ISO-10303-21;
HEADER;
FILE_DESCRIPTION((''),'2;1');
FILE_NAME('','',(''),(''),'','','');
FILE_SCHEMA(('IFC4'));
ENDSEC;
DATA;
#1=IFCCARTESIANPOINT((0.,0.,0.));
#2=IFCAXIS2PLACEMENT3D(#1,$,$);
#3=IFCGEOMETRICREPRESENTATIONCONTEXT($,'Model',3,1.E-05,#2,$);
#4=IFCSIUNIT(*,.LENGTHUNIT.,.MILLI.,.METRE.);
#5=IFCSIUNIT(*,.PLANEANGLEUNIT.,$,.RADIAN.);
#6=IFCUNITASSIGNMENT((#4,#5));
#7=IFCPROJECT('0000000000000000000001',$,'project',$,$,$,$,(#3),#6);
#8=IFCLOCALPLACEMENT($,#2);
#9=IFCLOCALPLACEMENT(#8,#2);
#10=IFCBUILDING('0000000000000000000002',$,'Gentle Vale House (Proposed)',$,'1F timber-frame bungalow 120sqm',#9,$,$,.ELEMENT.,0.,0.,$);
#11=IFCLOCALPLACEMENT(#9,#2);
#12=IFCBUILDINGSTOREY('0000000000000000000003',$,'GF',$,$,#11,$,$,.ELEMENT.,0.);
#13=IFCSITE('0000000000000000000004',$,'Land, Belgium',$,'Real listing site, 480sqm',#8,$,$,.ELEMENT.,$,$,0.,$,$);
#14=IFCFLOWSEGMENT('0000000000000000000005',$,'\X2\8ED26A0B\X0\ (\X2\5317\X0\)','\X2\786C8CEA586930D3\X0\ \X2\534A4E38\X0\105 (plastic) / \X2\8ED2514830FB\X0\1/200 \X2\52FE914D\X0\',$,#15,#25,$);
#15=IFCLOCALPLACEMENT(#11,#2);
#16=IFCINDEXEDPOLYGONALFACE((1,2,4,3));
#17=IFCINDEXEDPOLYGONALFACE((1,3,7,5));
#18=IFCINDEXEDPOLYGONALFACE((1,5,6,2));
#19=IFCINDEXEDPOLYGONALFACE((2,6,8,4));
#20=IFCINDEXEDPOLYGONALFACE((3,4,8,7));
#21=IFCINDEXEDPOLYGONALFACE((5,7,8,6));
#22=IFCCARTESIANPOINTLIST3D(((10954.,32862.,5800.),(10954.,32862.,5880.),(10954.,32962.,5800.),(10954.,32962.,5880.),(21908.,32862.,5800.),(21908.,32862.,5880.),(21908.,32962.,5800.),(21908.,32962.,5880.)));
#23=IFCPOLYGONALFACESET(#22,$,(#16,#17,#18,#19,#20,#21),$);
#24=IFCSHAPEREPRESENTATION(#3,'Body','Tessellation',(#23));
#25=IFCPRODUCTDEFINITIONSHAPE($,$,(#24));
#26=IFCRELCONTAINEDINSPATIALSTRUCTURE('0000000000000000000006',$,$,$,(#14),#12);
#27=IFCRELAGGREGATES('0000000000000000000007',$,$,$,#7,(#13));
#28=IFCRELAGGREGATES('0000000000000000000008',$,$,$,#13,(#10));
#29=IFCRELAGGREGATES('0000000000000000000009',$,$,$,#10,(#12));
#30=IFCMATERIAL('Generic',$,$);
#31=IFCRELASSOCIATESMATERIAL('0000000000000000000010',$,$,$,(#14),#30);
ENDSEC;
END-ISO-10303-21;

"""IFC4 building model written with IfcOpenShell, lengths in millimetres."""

from ifc_helpers import new_model, si_unit, frame, frame_2d, origin, place, context, project, spatial, rectangle, extrude, material, element, save


model = new_model("IFC4")

# Units and contexts
model_context = context("Model", 3, precision=1e-05, world=origin())
ifc_project = project(units=[si_unit("LENGTHUNIT", "METRE", prefix="MILLI"), si_unit("PLANEANGLEUNIT", "RADIAN")], contexts=[model_context])

# Site, building, storey
site_placement = place(None, origin())
site = spatial("IfcSite", under=ifc_project, at=site_placement, Name="Land, Belgium", ObjectType="Real listing site, 480sqm", CompositionType="ELEMENT", RefElevation=0.0)
building_placement = place(site_placement, origin())
building = spatial("IfcBuilding", under=site, at=building_placement, Name="Gentle Vale House (Proposed)", ObjectType="1F timber-frame bungalow 120sqm", CompositionType="ELEMENT", ElevationOfRefHeight=0.0, ElevationOfTerrain=0.0)
storey_placement = place(building_placement, origin())
storey = spatial("IfcBuildingStorey", under=building, at=storey_placement, Name="GF", CompositionType="ELEMENT", Elevation=0.0)

# Shared definitions
ifc_material_1 = material(Name="Generic")

# Flow segment
flow_segment_1_placement = place(storey_placement, frame((5477.0, 16431.0, 2900.0)))
element("IfcFlowSegment", 1, at=flow_segment_1_placement, inside=storey, material=ifc_material_1, Name="軒樋 (北)", Description="硬質塩ビ 半丸105 (plastic) / 軒先・1/200 勾配", context=model_context, shape_type="SweptSolid", body=[
    extrude(rectangle(XDim=10954.0, YDim=100.0, at=frame_2d((5477.0, 50.0))), frame((5477.0, 16431.0, 2900.0)), (0.0, 0.0, 1.0), 80.0),
])

save(model, "model.ifc")
